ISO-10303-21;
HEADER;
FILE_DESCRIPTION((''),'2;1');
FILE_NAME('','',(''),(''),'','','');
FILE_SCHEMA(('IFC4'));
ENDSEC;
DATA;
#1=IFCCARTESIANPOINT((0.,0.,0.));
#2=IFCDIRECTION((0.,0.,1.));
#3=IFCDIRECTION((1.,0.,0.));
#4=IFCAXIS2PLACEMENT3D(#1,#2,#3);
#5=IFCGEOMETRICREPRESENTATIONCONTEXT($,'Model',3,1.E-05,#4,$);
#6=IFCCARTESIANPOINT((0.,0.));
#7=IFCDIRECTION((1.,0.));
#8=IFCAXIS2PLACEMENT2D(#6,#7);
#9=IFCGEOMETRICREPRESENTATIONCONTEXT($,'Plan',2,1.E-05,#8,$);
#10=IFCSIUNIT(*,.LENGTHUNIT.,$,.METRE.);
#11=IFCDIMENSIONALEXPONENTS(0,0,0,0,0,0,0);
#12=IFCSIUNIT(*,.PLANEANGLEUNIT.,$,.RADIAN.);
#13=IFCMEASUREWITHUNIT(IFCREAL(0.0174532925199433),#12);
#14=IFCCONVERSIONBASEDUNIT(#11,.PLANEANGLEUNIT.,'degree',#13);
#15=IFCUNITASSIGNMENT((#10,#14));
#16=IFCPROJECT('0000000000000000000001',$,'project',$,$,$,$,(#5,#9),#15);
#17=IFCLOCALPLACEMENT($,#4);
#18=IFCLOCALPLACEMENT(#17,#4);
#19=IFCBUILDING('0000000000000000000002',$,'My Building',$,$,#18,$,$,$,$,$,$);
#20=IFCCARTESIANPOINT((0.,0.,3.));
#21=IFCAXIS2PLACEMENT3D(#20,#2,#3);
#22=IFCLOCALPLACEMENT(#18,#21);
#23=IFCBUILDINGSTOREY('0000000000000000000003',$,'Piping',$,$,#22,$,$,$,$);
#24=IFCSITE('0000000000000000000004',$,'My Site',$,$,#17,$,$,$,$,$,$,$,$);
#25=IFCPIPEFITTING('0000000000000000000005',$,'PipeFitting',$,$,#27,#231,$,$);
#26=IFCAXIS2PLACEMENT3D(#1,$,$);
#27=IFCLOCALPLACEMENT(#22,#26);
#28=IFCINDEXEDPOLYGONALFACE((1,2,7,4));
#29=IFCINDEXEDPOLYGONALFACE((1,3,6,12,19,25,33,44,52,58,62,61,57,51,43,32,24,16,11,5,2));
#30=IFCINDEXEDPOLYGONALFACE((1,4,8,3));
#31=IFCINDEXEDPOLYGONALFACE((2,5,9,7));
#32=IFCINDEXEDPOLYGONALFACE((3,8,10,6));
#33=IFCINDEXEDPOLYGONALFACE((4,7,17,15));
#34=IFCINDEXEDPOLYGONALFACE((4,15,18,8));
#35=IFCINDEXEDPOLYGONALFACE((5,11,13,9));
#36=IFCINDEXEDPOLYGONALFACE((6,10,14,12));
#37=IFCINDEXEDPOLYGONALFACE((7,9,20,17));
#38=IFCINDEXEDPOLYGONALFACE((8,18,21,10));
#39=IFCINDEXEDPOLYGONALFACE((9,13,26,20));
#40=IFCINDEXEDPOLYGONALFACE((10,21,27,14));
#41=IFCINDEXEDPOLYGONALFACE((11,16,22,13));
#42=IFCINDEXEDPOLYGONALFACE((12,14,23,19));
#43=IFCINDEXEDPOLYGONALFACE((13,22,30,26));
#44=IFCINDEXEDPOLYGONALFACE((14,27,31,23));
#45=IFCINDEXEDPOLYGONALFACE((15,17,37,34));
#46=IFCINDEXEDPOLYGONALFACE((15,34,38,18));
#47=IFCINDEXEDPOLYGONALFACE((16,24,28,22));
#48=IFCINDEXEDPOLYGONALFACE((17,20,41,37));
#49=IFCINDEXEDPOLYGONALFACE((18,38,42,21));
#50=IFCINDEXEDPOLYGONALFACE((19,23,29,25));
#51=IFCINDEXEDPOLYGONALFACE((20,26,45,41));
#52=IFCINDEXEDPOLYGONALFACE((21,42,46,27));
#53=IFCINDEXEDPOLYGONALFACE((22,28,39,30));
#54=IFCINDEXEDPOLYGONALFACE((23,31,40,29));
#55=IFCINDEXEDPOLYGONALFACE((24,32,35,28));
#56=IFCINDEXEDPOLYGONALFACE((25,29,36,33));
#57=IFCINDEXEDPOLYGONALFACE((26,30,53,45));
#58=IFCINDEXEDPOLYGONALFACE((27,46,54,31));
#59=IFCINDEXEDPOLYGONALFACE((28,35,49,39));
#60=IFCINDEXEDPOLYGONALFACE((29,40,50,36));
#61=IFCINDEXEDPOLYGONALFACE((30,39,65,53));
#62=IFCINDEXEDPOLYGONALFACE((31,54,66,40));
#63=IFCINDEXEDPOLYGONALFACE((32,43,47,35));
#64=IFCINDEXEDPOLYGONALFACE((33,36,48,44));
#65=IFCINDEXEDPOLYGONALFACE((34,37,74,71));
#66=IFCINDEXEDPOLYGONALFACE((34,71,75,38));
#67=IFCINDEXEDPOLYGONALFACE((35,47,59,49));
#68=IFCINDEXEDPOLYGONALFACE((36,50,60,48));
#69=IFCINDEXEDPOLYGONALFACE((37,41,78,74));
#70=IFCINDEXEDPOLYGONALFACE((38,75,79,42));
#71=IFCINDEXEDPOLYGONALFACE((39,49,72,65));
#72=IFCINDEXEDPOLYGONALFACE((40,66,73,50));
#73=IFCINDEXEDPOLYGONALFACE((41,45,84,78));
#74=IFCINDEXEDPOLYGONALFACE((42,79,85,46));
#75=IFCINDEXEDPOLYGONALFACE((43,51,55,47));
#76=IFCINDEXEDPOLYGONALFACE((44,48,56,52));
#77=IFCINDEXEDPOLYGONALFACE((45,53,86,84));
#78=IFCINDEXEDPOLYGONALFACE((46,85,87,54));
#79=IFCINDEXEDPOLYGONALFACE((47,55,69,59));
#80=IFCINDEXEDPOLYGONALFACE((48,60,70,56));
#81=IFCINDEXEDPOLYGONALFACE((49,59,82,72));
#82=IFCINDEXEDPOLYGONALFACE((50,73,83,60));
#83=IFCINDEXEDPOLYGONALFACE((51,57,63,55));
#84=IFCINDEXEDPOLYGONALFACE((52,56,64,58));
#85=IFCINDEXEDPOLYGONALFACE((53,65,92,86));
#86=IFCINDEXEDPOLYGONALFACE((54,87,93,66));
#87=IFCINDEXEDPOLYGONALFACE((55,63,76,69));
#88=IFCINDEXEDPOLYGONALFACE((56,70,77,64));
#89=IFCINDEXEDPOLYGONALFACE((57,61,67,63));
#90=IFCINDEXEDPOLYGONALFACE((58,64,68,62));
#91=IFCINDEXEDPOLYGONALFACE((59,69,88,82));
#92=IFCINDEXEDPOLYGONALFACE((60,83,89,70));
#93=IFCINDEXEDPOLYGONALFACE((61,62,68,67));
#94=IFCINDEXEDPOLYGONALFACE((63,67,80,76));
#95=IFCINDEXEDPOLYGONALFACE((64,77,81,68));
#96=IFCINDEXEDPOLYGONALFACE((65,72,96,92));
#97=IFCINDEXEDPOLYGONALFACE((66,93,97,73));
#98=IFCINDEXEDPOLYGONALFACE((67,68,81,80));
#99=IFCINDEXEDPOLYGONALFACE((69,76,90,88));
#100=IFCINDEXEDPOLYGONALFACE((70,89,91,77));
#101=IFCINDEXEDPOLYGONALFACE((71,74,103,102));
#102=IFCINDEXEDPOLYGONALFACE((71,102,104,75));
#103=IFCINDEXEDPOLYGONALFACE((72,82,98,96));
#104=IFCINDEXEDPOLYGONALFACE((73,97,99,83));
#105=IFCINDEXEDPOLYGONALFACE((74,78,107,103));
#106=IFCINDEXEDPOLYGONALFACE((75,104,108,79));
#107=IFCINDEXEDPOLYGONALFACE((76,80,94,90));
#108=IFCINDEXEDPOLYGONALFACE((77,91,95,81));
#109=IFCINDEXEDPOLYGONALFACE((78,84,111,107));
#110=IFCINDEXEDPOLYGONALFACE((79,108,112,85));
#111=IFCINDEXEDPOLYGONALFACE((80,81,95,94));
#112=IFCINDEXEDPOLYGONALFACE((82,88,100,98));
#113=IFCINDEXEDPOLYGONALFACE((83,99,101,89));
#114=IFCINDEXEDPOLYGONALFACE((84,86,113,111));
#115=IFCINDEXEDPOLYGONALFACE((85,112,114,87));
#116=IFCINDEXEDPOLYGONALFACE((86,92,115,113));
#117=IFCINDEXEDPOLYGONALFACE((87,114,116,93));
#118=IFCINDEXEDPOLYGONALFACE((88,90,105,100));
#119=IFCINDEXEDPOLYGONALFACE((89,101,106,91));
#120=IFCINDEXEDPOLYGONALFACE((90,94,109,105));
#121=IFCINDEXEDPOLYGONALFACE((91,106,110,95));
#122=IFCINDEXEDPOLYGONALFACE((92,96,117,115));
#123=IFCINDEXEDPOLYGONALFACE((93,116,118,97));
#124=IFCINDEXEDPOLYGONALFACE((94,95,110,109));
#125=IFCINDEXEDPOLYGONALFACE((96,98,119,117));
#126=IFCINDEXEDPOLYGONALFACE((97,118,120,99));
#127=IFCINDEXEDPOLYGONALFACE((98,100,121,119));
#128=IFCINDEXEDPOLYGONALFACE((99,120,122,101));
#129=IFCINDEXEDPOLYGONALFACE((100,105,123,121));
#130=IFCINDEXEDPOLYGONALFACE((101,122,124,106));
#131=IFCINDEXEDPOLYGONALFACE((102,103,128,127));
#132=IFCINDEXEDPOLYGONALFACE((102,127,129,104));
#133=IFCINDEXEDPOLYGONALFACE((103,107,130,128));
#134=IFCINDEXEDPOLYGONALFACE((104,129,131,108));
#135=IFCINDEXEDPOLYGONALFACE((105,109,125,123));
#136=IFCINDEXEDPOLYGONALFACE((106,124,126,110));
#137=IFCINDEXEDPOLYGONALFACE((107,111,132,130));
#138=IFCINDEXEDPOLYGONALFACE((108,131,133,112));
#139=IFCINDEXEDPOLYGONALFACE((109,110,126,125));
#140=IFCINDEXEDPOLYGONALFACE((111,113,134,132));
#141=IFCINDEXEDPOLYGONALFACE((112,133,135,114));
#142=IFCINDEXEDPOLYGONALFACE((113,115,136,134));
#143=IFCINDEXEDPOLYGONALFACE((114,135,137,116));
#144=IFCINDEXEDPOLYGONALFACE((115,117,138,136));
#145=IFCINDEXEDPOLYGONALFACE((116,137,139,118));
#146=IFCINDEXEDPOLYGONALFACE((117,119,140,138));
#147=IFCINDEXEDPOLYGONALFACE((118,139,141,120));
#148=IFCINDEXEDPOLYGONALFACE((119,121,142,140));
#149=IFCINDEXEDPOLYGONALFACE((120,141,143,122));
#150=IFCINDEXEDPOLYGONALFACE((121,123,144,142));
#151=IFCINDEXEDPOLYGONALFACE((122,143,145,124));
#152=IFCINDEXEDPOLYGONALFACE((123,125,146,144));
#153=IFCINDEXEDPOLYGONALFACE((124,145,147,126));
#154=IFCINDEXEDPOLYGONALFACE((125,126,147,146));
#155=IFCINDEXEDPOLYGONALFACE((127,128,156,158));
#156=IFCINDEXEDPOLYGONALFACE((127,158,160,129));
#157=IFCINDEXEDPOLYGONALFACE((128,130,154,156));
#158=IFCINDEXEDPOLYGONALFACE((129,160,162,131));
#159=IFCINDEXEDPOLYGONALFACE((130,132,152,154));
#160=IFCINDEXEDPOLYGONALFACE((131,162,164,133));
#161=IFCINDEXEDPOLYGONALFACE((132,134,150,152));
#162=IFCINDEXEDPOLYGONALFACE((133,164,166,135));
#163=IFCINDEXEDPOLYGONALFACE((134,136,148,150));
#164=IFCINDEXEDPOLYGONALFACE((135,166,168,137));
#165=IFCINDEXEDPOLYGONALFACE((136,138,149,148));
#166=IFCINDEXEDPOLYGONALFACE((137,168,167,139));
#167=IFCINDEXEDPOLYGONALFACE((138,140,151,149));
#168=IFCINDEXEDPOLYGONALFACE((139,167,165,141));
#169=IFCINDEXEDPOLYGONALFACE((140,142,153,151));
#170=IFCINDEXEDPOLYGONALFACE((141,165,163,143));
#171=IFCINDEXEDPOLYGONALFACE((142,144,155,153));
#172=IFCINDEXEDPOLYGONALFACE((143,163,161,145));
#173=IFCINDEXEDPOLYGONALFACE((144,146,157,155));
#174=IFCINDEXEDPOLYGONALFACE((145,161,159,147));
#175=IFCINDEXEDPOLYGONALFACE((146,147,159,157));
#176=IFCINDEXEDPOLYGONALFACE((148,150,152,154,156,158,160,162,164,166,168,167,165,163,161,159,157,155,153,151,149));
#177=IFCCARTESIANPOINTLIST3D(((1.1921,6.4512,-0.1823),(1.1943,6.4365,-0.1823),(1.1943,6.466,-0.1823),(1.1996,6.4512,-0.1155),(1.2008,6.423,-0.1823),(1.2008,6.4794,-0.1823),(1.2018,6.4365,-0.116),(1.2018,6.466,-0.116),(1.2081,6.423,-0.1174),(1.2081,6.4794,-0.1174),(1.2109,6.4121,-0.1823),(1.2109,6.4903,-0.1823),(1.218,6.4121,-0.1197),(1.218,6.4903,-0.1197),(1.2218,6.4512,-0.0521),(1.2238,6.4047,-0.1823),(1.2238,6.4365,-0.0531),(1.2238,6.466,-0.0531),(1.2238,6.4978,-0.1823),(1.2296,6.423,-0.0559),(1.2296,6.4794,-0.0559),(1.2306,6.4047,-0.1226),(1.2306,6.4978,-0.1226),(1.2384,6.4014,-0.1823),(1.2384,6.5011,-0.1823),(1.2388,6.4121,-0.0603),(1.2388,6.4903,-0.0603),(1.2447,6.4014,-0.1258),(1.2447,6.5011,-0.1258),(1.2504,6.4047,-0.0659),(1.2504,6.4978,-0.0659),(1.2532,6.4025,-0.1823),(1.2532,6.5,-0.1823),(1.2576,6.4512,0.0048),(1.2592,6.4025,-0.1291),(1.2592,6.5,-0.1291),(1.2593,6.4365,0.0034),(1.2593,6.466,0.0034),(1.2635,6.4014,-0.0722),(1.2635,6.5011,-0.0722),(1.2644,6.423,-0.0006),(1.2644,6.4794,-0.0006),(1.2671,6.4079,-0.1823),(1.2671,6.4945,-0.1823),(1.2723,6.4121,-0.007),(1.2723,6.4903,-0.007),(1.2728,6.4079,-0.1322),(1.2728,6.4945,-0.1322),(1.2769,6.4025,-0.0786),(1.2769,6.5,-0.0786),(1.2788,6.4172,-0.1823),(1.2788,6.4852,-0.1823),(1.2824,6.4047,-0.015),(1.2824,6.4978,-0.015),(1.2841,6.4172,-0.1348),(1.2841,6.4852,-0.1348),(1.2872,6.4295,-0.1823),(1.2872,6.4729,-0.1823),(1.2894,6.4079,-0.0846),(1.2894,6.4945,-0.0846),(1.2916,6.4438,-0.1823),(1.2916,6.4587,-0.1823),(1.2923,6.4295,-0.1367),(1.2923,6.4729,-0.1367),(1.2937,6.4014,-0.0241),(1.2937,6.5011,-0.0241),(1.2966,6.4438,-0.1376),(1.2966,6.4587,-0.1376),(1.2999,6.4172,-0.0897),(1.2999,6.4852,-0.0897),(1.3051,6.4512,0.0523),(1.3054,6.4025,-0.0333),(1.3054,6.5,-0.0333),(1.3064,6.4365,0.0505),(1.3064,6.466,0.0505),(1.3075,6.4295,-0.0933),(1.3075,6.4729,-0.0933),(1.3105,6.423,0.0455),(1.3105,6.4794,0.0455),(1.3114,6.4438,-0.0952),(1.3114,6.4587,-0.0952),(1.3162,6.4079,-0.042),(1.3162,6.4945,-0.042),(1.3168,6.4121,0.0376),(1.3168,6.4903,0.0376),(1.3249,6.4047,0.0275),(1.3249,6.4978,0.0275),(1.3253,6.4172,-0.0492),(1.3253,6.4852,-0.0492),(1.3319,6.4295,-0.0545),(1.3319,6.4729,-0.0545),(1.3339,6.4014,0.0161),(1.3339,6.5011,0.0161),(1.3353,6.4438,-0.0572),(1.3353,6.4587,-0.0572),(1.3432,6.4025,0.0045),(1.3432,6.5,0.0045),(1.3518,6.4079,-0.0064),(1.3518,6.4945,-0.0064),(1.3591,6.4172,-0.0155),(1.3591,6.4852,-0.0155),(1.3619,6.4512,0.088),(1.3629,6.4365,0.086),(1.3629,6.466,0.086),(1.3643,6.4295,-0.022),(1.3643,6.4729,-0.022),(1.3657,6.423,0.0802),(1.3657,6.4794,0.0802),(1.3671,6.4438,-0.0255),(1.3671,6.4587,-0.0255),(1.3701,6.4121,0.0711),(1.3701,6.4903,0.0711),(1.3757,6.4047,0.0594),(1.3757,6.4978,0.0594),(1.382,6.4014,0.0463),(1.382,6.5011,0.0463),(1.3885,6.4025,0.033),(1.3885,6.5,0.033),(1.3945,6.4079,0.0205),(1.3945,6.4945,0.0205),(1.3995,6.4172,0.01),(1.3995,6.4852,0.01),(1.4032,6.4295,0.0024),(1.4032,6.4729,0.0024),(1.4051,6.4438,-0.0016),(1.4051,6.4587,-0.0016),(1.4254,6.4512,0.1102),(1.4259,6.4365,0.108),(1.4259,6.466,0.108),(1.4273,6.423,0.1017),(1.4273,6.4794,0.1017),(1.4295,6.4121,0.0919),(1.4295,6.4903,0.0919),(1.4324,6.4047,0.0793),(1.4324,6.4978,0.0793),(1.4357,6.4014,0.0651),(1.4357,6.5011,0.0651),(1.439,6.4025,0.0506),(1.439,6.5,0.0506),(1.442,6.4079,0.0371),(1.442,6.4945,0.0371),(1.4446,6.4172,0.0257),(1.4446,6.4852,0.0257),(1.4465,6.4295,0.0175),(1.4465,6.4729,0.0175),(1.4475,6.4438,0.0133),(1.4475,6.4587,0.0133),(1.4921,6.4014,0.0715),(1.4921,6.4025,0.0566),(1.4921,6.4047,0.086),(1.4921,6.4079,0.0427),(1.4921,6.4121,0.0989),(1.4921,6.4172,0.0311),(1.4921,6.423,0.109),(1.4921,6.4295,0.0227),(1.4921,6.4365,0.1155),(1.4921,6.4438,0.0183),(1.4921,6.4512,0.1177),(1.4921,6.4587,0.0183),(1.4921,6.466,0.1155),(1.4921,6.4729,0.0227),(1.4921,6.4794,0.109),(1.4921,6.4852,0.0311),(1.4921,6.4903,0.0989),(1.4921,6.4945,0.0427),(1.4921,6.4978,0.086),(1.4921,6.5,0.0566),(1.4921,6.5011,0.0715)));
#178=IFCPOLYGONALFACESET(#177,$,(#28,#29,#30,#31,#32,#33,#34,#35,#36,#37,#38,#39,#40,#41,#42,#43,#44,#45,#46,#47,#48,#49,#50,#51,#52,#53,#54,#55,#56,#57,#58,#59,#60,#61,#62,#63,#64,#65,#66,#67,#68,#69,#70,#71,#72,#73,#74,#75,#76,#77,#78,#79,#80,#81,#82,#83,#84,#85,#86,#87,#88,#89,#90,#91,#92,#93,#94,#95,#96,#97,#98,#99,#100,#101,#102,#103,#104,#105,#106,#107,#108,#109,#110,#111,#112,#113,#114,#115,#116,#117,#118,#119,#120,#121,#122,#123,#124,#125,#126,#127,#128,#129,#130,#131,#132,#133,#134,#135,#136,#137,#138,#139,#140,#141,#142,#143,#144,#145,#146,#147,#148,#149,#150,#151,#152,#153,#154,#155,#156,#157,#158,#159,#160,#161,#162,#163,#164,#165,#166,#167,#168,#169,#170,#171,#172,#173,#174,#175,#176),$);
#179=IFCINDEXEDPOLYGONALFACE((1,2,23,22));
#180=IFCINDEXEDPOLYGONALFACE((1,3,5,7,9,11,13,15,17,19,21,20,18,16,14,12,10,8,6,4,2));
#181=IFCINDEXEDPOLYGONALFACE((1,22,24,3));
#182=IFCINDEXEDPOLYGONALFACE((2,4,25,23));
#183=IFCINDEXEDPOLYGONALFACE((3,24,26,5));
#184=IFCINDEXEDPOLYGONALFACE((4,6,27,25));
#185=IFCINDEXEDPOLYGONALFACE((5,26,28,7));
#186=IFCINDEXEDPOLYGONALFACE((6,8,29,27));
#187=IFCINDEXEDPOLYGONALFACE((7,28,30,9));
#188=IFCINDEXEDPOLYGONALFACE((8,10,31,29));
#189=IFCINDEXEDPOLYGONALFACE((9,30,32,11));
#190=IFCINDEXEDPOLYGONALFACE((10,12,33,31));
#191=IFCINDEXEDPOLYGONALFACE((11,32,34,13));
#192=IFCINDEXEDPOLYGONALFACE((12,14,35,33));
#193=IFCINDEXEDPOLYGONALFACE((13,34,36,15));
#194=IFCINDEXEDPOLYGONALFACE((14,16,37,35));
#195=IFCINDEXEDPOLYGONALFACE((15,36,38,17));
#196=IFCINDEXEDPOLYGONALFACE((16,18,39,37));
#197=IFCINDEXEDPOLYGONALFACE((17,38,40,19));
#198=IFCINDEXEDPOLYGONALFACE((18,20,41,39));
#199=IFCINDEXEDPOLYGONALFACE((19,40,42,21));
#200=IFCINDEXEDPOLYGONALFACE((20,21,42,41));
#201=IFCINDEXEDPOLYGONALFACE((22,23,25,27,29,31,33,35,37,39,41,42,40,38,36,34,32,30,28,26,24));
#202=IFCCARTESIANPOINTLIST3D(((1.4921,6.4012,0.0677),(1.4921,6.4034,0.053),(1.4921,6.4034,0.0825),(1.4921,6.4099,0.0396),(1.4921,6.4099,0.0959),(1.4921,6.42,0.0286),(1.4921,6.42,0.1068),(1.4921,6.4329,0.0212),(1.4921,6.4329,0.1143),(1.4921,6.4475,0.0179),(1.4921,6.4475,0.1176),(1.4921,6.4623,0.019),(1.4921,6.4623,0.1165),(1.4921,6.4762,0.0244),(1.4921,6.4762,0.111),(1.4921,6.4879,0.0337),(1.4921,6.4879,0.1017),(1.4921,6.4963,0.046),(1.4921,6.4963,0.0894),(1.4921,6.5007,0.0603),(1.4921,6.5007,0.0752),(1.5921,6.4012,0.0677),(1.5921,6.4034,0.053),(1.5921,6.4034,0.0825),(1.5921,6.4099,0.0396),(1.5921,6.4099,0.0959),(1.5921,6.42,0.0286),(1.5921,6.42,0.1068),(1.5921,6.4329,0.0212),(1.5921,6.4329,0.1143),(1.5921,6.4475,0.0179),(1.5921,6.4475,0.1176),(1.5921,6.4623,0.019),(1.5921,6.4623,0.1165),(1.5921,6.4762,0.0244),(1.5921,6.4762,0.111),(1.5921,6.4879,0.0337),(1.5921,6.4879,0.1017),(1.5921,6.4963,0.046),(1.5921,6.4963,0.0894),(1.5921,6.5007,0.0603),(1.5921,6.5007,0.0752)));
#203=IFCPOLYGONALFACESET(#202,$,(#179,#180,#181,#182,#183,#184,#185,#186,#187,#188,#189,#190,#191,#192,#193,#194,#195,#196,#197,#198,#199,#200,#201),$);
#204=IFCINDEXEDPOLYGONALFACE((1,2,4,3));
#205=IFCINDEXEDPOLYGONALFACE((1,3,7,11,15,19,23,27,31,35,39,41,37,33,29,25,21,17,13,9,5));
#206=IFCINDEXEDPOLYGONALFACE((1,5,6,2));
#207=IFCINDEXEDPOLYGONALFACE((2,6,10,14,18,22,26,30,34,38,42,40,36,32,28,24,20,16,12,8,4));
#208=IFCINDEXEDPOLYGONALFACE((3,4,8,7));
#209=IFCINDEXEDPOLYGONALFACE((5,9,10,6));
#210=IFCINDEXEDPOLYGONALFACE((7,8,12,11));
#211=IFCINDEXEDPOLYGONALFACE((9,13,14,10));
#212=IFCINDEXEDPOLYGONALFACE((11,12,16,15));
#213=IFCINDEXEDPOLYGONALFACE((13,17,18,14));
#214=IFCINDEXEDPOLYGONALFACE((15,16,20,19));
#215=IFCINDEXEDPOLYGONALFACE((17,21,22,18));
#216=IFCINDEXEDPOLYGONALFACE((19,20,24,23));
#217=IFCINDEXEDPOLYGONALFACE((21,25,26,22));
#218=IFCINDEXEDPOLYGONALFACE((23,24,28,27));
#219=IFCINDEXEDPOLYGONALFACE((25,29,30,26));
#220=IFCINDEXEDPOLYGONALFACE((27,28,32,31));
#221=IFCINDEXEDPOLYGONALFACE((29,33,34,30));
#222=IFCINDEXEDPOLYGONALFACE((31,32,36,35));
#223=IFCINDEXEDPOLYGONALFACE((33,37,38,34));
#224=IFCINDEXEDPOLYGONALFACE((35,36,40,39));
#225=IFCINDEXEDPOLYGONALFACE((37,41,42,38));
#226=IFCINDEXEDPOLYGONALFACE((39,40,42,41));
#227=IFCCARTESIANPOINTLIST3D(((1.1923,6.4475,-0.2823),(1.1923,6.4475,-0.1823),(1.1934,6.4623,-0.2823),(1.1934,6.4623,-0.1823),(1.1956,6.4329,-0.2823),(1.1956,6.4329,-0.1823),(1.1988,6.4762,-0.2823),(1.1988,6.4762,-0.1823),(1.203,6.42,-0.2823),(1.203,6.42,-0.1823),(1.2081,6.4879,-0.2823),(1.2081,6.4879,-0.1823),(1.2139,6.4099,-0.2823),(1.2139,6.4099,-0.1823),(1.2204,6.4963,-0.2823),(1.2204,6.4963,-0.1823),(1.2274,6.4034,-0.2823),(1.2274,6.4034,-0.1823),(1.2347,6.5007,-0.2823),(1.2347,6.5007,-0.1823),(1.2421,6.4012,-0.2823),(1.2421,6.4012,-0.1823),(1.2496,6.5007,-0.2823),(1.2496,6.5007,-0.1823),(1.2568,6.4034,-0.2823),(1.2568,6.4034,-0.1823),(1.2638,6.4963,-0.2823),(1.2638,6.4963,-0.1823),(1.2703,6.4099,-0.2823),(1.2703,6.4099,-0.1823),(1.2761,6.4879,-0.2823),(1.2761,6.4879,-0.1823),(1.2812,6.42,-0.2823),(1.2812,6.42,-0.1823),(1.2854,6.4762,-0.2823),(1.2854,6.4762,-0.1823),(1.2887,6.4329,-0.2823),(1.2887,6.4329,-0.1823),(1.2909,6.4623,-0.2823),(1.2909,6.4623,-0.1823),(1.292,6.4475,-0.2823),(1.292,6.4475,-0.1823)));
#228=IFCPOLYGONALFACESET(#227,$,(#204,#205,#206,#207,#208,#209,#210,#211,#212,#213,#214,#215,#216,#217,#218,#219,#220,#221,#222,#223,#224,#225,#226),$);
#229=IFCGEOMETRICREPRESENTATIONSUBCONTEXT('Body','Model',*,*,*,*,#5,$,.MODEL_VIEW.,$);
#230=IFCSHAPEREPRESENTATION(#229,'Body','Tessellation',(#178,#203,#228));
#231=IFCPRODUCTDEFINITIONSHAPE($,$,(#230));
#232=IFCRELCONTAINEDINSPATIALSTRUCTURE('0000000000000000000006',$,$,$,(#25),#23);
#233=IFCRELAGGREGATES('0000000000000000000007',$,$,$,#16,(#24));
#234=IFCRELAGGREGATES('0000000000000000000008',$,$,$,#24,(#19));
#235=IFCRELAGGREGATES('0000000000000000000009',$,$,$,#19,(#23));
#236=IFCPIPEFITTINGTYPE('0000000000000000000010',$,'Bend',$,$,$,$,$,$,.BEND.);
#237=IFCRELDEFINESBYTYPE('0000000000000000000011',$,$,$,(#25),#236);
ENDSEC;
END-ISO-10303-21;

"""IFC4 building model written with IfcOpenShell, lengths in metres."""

from ifc_helpers import new_model, entity, si_unit, converted_unit, frame, origin_with_axes, origin_2d_with_axis, place, context, subcontext, project, spatial, circle, extrude, source, transform, mapped, type_object, type_shapes, element, save


model = new_model("IFC4")

# Units and contexts
model_context = context("Model", 3, precision=1e-05, world=origin_with_axes())
plan_context = context("Plan", 2, precision=1e-05, world=origin_2d_with_axis())
body_context = subcontext(model_context, "Body", "Model", "MODEL_VIEW")
ifc_project = project(units=[si_unit("LENGTHUNIT", "METRE"), converted_unit("PLANEANGLEUNIT", "degree", entity("IfcReal", 0.0174532925199433), si_unit("PLANEANGLEUNIT", "RADIAN"), dimensions=[0, 0, 0, 0, 0, 0, 0])], contexts=[model_context, plan_context])

# Site, building, storey
site_placement = place(None, origin_with_axes())
site = spatial("IfcSite", under=ifc_project, at=site_placement, Name="My Site")
building_placement = place(site_placement, origin_with_axes())
building = spatial("IfcBuilding", under=site, at=building_placement, Name="My Building")
storey_placement = place(building_placement, frame((0.0, 0.0, 3.0), z_axis=(0.0, 0.0, 1.0), x_axis=(1.0, 0.0, 0.0)))
storey = spatial("IfcBuildingStorey", under=building, at=storey_placement, Name="Piping")

# Pipe fitting
pipe_fitting_type_1 = type_object("IfcPipeFittingType", Name="Bend", PredefinedType="BEND")
shared_shape = source(origin_with_axes(), body_context, "Body", "SolidModel", [
    entity("IfcSweptDiskSolid", entity("IfcIndexedPolyCurve", entity("IfcCartesianPointList3D", [[0.0, 0.0, 0.1], [0.0, -0.0732, 0.2768], [0.0, -0.25, 0.35]]), [entity("IfcArcIndex", [1, 2, 3])]), 0.05),
    extrude(circle(Radius=0.05), origin_with_axes(), (0.0, 0.0, 1.0), 0.1),
    extrude(circle(Radius=0.05), frame((0.0, -0.25, 0.35), z_axis=(0.0, -1.0, -0.000002), x_axis=(1.0, 0.0, 0.0)), (0.0, 0.0, 1.0), 0.1),
])
type_shapes(pipe_fitting_type_1, [shared_shape])
for number, where, z_axis, x_axis, name in (
    (1, (1.5921, 6.4512, 0.0677), (-1.0, 0.0, 0.000002), (0.0, -1.0, 0.0), "PipeFitting"),
):
    element("IfcPipeFitting", number, at=place(storey_placement, frame(where, z_axis=z_axis, x_axis=x_axis)), inside=storey, type_object=pipe_fitting_type_1, Name=name, context=body_context, shape_type="MappedRepresentation", body=[
        mapped(shared_shape, transform((0.0, 0.0, 0.0), x_axis=(1.0, 0.0, 0.0), y_axis=(0.0, 1.0, 0.0), z_axis=(0.0, 0.0, 1.0), scale=1.0)),
    ])

save(model, "model.ifc")
